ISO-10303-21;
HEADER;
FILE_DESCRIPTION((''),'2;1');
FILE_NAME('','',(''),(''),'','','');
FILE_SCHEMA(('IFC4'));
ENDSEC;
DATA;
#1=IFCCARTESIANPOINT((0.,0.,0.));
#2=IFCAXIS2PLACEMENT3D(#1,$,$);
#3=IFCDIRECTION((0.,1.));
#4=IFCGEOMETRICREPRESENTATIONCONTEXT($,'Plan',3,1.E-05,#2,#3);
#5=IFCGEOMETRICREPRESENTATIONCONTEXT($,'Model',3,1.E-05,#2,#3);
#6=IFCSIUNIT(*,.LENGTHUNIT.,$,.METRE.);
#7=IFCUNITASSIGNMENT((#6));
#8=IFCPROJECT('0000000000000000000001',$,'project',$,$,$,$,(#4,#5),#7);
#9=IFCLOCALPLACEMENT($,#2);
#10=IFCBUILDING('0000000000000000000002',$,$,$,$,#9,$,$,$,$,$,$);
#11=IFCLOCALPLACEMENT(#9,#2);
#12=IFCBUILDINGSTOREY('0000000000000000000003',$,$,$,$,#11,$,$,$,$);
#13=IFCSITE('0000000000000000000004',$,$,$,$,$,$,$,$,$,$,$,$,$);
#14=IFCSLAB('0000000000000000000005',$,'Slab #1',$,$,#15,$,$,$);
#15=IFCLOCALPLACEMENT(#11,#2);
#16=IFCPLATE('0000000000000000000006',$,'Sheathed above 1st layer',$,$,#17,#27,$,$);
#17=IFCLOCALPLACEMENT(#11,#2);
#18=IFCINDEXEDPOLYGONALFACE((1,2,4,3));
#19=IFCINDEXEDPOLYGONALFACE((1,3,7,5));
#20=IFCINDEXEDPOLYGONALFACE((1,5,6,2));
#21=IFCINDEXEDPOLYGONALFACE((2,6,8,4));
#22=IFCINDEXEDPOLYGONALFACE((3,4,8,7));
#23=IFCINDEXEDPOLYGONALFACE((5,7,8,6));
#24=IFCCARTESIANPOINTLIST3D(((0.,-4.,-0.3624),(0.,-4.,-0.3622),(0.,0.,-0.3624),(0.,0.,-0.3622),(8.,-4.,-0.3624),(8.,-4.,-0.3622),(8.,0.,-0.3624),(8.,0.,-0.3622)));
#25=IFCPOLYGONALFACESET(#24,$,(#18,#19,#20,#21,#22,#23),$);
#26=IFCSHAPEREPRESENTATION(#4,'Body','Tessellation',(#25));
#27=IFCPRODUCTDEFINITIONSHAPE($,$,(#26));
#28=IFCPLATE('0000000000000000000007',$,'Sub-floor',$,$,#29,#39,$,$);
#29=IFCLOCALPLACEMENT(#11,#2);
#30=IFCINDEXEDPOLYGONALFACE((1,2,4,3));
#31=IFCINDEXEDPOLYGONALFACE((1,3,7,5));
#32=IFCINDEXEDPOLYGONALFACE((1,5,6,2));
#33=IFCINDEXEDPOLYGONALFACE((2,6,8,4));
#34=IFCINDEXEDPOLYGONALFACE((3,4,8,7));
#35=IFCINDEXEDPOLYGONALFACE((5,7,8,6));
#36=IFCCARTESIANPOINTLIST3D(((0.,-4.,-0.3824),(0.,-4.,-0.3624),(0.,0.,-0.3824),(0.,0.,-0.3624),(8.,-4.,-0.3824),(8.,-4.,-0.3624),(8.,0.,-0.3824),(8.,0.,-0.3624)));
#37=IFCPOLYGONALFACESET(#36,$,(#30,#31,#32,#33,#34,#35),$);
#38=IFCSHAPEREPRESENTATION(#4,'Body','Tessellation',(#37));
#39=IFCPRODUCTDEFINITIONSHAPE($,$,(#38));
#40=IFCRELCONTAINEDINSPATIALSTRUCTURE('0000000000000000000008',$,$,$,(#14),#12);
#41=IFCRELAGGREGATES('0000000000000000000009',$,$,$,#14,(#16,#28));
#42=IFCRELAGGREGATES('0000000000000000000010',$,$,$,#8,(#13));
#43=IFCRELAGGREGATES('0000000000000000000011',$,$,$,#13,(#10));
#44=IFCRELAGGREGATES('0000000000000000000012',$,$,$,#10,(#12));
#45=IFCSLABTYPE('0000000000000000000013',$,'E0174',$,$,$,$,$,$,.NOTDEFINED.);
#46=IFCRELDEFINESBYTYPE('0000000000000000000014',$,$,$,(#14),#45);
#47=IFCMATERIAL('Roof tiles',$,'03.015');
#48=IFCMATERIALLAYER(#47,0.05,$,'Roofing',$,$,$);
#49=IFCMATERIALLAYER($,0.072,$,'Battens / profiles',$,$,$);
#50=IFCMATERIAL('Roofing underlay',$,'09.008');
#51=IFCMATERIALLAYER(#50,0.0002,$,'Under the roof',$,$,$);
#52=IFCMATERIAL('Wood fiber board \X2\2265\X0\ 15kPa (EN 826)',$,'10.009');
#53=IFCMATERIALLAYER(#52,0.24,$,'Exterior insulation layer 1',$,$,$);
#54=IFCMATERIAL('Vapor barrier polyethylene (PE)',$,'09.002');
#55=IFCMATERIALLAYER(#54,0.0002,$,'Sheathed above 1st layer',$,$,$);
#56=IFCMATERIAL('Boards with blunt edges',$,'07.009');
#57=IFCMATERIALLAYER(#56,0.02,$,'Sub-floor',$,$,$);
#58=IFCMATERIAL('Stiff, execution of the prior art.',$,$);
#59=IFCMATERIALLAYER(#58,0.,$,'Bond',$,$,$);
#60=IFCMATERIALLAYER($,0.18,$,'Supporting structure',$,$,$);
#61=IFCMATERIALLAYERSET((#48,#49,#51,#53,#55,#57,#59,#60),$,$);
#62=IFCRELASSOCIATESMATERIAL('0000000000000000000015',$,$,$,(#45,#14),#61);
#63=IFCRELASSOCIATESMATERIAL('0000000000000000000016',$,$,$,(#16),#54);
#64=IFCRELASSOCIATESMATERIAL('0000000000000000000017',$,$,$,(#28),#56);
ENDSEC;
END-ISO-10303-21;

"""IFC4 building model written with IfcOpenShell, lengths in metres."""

from ifc_helpers import new_model, si_unit, direction, frame, frame_2d, origin, place, context, project, spatial, rectangle, extrude, material, layer, layer_set, type_object, element, aggregate, save


model = new_model("IFC4")

# Units and contexts
plan_context = context("Plan", 3, precision=1e-05, world=origin(), true_north=direction((0.0, 1.0)))
model_context = context("Model", 3, precision=1e-05, world=origin(), true_north=direction((0.0, 1.0)))
ifc_project = project(units=[si_unit("LENGTHUNIT", "METRE")], contexts=[plan_context, model_context])

# Site, building, storey
site = spatial("IfcSite", under=ifc_project)
building_placement = place(None, origin())
building = spatial("IfcBuilding", under=site, at=building_placement)
storey_placement = place(building_placement, origin())
storey = spatial("IfcBuildingStorey", under=building, at=storey_placement)

# Slab, plates
ifc_material_1 = material(Name="Roof tiles", Category="03.015")
ifc_layer_1 = layer(ifc_material_1, 0.05, Name="Roofing")
ifc_layer_2 = layer(None, 0.072, Name="Battens / profiles")
ifc_material_2 = material(Name="Roofing underlay", Category="09.008")
ifc_layer_3 = layer(ifc_material_2, 0.0002, Name="Under the roof")
ifc_material_3 = material(Name="Wood fiber board ≥ 15kPa (EN 826)", Category="10.009")
ifc_layer_4 = layer(ifc_material_3, 0.24, Name="Exterior insulation layer 1")
ifc_material_4 = material(Name="Vapor barrier polyethylene (PE)", Category="09.002")
ifc_layer_5 = layer(ifc_material_4, 0.0002, Name="Sheathed above 1st layer")
ifc_material_5 = material(Name="Boards with blunt edges", Category="07.009")
ifc_layer_6 = layer(ifc_material_5, 0.02, Name="Sub-floor")
ifc_material_6 = material(Name="Stiff, execution of the prior art.")
ifc_layer_7 = layer(ifc_material_6, 0.0, Name="Bond")
ifc_layer_8 = layer(None, 0.18, Name="Supporting structure")
ifc_layer_set = layer_set([ifc_layer_1, ifc_layer_2, ifc_layer_3, ifc_layer_4, ifc_layer_5, ifc_layer_6, ifc_layer_7, ifc_layer_8])
slab_type = type_object("IfcSlabType", Name="E0174", PredefinedType="NOTDEFINED", material=ifc_layer_set)
slab_placement = place(None, frame((0.0, 0.0, 0.0), z_axis=(0.0, 0.0, -1.0), x_axis=(1.0, 0.0, 0.0)))
slab = element("IfcSlab", 1, at=slab_placement, inside=storey, type_object=slab_type, material=ifc_layer_set, Name="Slab #1")
plate_1_placement = place(slab_placement, origin())
plate_1 = element("IfcPlate", 2, at=plate_1_placement, material=ifc_material_4, Name="Sheathed above 1st layer", context=plan_context, shape_type="SweptSolid", body=[
    extrude(rectangle(XDim=8.0, YDim=4.0, at=frame_2d((4.0, 2.0), x_axis=(1.0, 0.0))), frame((0.0, 0.0, 0.3622), z_axis=(0.0, 0.0, 1.0), x_axis=(1.0, 0.0, 0.0)), (0.0, 0.0, 1.0), 0.0002),
])
plate_2_placement = place(slab_placement, origin())
plate_2 = element("IfcPlate", 3, at=plate_2_placement, material=ifc_material_5, Name="Sub-floor", context=plan_context, shape_type="SweptSolid", body=[
    extrude(rectangle(XDim=8.0, YDim=4.0, at=frame_2d((4.0, 2.0), x_axis=(1.0, 0.0))), frame((0.0, 0.0, 0.3624), z_axis=(0.0, 0.0, 1.0), x_axis=(1.0, 0.0, 0.0)), (0.0, 0.0, 1.0), 0.02),
])
aggregate(slab, [plate_1, plate_2])

save(model, "model.ifc")
